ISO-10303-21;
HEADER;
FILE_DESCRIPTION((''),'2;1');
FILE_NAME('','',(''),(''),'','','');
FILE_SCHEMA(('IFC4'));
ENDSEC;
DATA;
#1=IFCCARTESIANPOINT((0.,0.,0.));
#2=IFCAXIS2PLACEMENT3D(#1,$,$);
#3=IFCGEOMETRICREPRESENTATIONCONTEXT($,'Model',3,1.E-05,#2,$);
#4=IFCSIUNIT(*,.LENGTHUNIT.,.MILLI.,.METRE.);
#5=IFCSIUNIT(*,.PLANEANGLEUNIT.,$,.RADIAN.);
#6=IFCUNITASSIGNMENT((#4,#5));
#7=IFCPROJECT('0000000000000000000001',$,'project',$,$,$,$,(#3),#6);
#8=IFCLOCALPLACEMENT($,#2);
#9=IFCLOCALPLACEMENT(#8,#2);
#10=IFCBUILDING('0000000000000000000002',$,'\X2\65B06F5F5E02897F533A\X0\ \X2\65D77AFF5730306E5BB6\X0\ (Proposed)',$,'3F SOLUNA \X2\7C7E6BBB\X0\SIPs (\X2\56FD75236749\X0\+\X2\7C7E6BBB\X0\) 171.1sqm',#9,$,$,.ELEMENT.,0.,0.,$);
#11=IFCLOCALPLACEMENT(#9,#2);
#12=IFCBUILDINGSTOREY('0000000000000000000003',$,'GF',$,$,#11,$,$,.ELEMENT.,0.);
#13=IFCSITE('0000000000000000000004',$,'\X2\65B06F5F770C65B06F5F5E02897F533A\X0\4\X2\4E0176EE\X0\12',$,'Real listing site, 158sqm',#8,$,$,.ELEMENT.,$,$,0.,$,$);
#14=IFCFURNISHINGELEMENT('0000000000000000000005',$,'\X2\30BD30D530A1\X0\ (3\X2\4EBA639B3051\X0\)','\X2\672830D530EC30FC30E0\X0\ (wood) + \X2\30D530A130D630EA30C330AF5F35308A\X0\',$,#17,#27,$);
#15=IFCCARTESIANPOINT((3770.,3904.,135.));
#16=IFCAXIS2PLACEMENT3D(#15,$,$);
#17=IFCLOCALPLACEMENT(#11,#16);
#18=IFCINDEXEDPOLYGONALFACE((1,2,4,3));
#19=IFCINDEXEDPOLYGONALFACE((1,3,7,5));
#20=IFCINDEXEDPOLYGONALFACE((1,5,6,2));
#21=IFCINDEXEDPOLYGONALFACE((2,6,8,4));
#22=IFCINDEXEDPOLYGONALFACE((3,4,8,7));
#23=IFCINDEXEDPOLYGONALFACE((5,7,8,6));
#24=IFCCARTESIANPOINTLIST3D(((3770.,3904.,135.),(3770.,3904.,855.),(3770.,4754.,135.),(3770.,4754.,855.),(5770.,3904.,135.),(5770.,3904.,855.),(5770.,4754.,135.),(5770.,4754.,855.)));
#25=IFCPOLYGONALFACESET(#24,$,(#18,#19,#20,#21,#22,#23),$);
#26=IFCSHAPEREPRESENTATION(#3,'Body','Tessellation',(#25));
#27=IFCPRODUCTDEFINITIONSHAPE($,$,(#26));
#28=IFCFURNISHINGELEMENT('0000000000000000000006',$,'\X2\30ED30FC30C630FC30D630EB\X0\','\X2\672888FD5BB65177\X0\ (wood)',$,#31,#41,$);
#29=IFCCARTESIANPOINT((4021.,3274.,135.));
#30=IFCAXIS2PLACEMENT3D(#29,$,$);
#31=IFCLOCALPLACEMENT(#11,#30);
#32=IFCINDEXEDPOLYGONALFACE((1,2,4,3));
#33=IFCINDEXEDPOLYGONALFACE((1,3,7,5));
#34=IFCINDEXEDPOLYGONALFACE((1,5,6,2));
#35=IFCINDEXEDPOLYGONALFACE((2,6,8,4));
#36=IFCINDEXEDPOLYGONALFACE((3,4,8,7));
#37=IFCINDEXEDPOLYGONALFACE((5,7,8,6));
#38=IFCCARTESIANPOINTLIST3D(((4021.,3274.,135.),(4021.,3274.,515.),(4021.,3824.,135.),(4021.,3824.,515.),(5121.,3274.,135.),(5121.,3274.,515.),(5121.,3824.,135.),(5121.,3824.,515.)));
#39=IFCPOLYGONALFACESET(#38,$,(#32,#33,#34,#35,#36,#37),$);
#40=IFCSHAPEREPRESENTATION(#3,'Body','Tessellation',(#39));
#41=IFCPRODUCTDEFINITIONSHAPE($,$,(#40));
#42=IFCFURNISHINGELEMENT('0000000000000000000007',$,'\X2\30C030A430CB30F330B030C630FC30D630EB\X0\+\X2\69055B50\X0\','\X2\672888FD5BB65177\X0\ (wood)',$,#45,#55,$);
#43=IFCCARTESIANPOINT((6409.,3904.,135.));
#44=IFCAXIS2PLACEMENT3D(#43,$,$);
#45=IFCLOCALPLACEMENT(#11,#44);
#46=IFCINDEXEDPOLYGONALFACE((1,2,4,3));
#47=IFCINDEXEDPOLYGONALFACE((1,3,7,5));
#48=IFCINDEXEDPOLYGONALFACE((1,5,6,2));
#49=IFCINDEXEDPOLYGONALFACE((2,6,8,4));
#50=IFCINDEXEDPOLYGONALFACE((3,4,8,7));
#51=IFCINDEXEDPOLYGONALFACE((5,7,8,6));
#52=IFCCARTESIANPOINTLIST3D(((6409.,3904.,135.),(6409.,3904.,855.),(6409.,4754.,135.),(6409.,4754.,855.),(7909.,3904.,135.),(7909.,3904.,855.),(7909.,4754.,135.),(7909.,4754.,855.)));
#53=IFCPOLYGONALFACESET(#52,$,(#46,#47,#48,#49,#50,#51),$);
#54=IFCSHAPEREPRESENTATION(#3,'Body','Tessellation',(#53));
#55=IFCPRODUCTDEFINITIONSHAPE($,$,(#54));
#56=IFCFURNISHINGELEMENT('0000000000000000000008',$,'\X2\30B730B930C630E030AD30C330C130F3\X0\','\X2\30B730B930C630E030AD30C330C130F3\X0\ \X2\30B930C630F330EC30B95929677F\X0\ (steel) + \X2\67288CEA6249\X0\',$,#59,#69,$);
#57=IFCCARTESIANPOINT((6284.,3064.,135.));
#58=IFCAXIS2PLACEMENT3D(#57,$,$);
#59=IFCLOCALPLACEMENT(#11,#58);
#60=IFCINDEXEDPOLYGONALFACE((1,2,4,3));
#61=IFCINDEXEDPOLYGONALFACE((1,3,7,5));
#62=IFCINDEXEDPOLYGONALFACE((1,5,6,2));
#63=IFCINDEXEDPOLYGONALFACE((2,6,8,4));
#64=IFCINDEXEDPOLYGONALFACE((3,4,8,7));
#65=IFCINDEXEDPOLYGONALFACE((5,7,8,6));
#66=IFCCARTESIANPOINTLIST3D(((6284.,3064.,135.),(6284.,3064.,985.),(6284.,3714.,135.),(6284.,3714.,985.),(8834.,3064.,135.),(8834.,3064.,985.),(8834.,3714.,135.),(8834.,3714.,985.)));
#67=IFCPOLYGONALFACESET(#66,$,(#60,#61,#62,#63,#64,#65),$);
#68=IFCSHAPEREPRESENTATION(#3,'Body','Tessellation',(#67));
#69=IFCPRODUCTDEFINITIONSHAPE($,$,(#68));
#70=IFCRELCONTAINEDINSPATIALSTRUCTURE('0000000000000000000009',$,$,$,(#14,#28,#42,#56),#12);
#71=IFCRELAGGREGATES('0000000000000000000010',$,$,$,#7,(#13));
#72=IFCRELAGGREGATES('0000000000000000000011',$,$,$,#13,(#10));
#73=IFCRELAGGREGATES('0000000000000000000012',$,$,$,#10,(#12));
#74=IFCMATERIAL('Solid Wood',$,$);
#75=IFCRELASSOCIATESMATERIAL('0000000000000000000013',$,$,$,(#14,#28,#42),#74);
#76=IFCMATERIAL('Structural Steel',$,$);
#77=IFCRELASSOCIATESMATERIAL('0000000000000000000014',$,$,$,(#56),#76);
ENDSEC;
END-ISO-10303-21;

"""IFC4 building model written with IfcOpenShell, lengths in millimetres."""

from ifc_helpers import new_model, si_unit, frame, frame_2d, origin, place, context, project, spatial, rectangle, extrude, material, element, save


model = new_model("IFC4")

# Units and contexts
model_context = context("Model", 3, precision=1e-05, world=origin())
ifc_project = project(units=[si_unit("LENGTHUNIT", "METRE", prefix="MILLI"), si_unit("PLANEANGLEUNIT", "RADIAN")], contexts=[model_context])

# Site, building, storey
site_placement = place(None, origin())
site = spatial("IfcSite", under=ifc_project, at=site_placement, Name="新潟県新潟市西区4丁目12", ObjectType="Real listing site, 158sqm", CompositionType="ELEMENT", RefElevation=0.0)
building_placement = place(site_placement, origin())
building = spatial("IfcBuilding", under=site, at=building_placement, Name="新潟市西区 旗竿地の家 (Proposed)", ObjectType="3F SOLUNA 籾殻SIPs (国産杉+籾殻) 171.1sqm", CompositionType="ELEMENT", ElevationOfRefHeight=0.0, ElevationOfTerrain=0.0)
storey_placement = place(building_placement, origin())
storey = spatial("IfcBuildingStorey", under=building, at=storey_placement, Name="GF", CompositionType="ELEMENT", Elevation=0.0)

# Shared definitions
ifc_material_1 = material(Name="Solid Wood")

# Furnishing elements
furnishing_1_placement = place(storey_placement, frame((3770.0, 3904.0, 135.0)))
element("IfcFurnishingElement", 1, at=furnishing_1_placement, inside=storey, material=ifc_material_1, Name="ソファ (3人掛け)", Description="木フレーム (wood) + ファブリック張り", context=model_context, shape_type="SweptSolid", body=[
    extrude(rectangle(XDim=2000.0, YDim=850.0, at=frame_2d((1000.0, 425.0))), frame((3770.0, 3904.0, 135.0)), (0.0, 0.0, 1.0), 720.0),
])
furnishing_2_placement = place(storey_placement, frame((4021.0, 3274.0, 135.0)))
element("IfcFurnishingElement", 2, at=furnishing_2_placement, inside=storey, material=ifc_material_1, Name="ローテーブル", Description="木製家具 (wood)", context=model_context, shape_type="SweptSolid", body=[
    extrude(rectangle(XDim=1100.0, YDim=550.0, at=frame_2d((550.0, 275.0))), frame((4021.0, 3274.0, 135.0)), (0.0, 0.0, 1.0), 380.0),
])
furnishing_3_placement = place(storey_placement, frame((6409.0, 3904.0, 135.0)))
element("IfcFurnishingElement", 3, at=furnishing_3_placement, inside=storey, material=ifc_material_1, Name="ダイニングテーブル+椅子", Description="木製家具 (wood)", context=model_context, shape_type="SweptSolid", body=[
    extrude(rectangle(XDim=1500.0, YDim=850.0, at=frame_2d((750.0, 425.0))), frame((6409.0, 3904.0, 135.0)), (0.0, 0.0, 1.0), 720.0),
])
ifc_material_2 = material(Name="Structural Steel")
furnishing_4_placement = place(storey_placement, frame((6284.0, 3064.0, 135.0)))
element("IfcFurnishingElement", 4, at=furnishing_4_placement, inside=storey, material=ifc_material_2, Name="システムキッチン", Description="システムキッチン ステンレス天板 (steel) + 木質扉", context=model_context, shape_type="SweptSolid", body=[
    extrude(rectangle(XDim=2550.0, YDim=650.0, at=frame_2d((1275.0, 325.0))), frame((6284.0, 3064.0, 135.0)), (0.0, 0.0, 1.0), 850.0),
])

save(model, "model.ifc")
